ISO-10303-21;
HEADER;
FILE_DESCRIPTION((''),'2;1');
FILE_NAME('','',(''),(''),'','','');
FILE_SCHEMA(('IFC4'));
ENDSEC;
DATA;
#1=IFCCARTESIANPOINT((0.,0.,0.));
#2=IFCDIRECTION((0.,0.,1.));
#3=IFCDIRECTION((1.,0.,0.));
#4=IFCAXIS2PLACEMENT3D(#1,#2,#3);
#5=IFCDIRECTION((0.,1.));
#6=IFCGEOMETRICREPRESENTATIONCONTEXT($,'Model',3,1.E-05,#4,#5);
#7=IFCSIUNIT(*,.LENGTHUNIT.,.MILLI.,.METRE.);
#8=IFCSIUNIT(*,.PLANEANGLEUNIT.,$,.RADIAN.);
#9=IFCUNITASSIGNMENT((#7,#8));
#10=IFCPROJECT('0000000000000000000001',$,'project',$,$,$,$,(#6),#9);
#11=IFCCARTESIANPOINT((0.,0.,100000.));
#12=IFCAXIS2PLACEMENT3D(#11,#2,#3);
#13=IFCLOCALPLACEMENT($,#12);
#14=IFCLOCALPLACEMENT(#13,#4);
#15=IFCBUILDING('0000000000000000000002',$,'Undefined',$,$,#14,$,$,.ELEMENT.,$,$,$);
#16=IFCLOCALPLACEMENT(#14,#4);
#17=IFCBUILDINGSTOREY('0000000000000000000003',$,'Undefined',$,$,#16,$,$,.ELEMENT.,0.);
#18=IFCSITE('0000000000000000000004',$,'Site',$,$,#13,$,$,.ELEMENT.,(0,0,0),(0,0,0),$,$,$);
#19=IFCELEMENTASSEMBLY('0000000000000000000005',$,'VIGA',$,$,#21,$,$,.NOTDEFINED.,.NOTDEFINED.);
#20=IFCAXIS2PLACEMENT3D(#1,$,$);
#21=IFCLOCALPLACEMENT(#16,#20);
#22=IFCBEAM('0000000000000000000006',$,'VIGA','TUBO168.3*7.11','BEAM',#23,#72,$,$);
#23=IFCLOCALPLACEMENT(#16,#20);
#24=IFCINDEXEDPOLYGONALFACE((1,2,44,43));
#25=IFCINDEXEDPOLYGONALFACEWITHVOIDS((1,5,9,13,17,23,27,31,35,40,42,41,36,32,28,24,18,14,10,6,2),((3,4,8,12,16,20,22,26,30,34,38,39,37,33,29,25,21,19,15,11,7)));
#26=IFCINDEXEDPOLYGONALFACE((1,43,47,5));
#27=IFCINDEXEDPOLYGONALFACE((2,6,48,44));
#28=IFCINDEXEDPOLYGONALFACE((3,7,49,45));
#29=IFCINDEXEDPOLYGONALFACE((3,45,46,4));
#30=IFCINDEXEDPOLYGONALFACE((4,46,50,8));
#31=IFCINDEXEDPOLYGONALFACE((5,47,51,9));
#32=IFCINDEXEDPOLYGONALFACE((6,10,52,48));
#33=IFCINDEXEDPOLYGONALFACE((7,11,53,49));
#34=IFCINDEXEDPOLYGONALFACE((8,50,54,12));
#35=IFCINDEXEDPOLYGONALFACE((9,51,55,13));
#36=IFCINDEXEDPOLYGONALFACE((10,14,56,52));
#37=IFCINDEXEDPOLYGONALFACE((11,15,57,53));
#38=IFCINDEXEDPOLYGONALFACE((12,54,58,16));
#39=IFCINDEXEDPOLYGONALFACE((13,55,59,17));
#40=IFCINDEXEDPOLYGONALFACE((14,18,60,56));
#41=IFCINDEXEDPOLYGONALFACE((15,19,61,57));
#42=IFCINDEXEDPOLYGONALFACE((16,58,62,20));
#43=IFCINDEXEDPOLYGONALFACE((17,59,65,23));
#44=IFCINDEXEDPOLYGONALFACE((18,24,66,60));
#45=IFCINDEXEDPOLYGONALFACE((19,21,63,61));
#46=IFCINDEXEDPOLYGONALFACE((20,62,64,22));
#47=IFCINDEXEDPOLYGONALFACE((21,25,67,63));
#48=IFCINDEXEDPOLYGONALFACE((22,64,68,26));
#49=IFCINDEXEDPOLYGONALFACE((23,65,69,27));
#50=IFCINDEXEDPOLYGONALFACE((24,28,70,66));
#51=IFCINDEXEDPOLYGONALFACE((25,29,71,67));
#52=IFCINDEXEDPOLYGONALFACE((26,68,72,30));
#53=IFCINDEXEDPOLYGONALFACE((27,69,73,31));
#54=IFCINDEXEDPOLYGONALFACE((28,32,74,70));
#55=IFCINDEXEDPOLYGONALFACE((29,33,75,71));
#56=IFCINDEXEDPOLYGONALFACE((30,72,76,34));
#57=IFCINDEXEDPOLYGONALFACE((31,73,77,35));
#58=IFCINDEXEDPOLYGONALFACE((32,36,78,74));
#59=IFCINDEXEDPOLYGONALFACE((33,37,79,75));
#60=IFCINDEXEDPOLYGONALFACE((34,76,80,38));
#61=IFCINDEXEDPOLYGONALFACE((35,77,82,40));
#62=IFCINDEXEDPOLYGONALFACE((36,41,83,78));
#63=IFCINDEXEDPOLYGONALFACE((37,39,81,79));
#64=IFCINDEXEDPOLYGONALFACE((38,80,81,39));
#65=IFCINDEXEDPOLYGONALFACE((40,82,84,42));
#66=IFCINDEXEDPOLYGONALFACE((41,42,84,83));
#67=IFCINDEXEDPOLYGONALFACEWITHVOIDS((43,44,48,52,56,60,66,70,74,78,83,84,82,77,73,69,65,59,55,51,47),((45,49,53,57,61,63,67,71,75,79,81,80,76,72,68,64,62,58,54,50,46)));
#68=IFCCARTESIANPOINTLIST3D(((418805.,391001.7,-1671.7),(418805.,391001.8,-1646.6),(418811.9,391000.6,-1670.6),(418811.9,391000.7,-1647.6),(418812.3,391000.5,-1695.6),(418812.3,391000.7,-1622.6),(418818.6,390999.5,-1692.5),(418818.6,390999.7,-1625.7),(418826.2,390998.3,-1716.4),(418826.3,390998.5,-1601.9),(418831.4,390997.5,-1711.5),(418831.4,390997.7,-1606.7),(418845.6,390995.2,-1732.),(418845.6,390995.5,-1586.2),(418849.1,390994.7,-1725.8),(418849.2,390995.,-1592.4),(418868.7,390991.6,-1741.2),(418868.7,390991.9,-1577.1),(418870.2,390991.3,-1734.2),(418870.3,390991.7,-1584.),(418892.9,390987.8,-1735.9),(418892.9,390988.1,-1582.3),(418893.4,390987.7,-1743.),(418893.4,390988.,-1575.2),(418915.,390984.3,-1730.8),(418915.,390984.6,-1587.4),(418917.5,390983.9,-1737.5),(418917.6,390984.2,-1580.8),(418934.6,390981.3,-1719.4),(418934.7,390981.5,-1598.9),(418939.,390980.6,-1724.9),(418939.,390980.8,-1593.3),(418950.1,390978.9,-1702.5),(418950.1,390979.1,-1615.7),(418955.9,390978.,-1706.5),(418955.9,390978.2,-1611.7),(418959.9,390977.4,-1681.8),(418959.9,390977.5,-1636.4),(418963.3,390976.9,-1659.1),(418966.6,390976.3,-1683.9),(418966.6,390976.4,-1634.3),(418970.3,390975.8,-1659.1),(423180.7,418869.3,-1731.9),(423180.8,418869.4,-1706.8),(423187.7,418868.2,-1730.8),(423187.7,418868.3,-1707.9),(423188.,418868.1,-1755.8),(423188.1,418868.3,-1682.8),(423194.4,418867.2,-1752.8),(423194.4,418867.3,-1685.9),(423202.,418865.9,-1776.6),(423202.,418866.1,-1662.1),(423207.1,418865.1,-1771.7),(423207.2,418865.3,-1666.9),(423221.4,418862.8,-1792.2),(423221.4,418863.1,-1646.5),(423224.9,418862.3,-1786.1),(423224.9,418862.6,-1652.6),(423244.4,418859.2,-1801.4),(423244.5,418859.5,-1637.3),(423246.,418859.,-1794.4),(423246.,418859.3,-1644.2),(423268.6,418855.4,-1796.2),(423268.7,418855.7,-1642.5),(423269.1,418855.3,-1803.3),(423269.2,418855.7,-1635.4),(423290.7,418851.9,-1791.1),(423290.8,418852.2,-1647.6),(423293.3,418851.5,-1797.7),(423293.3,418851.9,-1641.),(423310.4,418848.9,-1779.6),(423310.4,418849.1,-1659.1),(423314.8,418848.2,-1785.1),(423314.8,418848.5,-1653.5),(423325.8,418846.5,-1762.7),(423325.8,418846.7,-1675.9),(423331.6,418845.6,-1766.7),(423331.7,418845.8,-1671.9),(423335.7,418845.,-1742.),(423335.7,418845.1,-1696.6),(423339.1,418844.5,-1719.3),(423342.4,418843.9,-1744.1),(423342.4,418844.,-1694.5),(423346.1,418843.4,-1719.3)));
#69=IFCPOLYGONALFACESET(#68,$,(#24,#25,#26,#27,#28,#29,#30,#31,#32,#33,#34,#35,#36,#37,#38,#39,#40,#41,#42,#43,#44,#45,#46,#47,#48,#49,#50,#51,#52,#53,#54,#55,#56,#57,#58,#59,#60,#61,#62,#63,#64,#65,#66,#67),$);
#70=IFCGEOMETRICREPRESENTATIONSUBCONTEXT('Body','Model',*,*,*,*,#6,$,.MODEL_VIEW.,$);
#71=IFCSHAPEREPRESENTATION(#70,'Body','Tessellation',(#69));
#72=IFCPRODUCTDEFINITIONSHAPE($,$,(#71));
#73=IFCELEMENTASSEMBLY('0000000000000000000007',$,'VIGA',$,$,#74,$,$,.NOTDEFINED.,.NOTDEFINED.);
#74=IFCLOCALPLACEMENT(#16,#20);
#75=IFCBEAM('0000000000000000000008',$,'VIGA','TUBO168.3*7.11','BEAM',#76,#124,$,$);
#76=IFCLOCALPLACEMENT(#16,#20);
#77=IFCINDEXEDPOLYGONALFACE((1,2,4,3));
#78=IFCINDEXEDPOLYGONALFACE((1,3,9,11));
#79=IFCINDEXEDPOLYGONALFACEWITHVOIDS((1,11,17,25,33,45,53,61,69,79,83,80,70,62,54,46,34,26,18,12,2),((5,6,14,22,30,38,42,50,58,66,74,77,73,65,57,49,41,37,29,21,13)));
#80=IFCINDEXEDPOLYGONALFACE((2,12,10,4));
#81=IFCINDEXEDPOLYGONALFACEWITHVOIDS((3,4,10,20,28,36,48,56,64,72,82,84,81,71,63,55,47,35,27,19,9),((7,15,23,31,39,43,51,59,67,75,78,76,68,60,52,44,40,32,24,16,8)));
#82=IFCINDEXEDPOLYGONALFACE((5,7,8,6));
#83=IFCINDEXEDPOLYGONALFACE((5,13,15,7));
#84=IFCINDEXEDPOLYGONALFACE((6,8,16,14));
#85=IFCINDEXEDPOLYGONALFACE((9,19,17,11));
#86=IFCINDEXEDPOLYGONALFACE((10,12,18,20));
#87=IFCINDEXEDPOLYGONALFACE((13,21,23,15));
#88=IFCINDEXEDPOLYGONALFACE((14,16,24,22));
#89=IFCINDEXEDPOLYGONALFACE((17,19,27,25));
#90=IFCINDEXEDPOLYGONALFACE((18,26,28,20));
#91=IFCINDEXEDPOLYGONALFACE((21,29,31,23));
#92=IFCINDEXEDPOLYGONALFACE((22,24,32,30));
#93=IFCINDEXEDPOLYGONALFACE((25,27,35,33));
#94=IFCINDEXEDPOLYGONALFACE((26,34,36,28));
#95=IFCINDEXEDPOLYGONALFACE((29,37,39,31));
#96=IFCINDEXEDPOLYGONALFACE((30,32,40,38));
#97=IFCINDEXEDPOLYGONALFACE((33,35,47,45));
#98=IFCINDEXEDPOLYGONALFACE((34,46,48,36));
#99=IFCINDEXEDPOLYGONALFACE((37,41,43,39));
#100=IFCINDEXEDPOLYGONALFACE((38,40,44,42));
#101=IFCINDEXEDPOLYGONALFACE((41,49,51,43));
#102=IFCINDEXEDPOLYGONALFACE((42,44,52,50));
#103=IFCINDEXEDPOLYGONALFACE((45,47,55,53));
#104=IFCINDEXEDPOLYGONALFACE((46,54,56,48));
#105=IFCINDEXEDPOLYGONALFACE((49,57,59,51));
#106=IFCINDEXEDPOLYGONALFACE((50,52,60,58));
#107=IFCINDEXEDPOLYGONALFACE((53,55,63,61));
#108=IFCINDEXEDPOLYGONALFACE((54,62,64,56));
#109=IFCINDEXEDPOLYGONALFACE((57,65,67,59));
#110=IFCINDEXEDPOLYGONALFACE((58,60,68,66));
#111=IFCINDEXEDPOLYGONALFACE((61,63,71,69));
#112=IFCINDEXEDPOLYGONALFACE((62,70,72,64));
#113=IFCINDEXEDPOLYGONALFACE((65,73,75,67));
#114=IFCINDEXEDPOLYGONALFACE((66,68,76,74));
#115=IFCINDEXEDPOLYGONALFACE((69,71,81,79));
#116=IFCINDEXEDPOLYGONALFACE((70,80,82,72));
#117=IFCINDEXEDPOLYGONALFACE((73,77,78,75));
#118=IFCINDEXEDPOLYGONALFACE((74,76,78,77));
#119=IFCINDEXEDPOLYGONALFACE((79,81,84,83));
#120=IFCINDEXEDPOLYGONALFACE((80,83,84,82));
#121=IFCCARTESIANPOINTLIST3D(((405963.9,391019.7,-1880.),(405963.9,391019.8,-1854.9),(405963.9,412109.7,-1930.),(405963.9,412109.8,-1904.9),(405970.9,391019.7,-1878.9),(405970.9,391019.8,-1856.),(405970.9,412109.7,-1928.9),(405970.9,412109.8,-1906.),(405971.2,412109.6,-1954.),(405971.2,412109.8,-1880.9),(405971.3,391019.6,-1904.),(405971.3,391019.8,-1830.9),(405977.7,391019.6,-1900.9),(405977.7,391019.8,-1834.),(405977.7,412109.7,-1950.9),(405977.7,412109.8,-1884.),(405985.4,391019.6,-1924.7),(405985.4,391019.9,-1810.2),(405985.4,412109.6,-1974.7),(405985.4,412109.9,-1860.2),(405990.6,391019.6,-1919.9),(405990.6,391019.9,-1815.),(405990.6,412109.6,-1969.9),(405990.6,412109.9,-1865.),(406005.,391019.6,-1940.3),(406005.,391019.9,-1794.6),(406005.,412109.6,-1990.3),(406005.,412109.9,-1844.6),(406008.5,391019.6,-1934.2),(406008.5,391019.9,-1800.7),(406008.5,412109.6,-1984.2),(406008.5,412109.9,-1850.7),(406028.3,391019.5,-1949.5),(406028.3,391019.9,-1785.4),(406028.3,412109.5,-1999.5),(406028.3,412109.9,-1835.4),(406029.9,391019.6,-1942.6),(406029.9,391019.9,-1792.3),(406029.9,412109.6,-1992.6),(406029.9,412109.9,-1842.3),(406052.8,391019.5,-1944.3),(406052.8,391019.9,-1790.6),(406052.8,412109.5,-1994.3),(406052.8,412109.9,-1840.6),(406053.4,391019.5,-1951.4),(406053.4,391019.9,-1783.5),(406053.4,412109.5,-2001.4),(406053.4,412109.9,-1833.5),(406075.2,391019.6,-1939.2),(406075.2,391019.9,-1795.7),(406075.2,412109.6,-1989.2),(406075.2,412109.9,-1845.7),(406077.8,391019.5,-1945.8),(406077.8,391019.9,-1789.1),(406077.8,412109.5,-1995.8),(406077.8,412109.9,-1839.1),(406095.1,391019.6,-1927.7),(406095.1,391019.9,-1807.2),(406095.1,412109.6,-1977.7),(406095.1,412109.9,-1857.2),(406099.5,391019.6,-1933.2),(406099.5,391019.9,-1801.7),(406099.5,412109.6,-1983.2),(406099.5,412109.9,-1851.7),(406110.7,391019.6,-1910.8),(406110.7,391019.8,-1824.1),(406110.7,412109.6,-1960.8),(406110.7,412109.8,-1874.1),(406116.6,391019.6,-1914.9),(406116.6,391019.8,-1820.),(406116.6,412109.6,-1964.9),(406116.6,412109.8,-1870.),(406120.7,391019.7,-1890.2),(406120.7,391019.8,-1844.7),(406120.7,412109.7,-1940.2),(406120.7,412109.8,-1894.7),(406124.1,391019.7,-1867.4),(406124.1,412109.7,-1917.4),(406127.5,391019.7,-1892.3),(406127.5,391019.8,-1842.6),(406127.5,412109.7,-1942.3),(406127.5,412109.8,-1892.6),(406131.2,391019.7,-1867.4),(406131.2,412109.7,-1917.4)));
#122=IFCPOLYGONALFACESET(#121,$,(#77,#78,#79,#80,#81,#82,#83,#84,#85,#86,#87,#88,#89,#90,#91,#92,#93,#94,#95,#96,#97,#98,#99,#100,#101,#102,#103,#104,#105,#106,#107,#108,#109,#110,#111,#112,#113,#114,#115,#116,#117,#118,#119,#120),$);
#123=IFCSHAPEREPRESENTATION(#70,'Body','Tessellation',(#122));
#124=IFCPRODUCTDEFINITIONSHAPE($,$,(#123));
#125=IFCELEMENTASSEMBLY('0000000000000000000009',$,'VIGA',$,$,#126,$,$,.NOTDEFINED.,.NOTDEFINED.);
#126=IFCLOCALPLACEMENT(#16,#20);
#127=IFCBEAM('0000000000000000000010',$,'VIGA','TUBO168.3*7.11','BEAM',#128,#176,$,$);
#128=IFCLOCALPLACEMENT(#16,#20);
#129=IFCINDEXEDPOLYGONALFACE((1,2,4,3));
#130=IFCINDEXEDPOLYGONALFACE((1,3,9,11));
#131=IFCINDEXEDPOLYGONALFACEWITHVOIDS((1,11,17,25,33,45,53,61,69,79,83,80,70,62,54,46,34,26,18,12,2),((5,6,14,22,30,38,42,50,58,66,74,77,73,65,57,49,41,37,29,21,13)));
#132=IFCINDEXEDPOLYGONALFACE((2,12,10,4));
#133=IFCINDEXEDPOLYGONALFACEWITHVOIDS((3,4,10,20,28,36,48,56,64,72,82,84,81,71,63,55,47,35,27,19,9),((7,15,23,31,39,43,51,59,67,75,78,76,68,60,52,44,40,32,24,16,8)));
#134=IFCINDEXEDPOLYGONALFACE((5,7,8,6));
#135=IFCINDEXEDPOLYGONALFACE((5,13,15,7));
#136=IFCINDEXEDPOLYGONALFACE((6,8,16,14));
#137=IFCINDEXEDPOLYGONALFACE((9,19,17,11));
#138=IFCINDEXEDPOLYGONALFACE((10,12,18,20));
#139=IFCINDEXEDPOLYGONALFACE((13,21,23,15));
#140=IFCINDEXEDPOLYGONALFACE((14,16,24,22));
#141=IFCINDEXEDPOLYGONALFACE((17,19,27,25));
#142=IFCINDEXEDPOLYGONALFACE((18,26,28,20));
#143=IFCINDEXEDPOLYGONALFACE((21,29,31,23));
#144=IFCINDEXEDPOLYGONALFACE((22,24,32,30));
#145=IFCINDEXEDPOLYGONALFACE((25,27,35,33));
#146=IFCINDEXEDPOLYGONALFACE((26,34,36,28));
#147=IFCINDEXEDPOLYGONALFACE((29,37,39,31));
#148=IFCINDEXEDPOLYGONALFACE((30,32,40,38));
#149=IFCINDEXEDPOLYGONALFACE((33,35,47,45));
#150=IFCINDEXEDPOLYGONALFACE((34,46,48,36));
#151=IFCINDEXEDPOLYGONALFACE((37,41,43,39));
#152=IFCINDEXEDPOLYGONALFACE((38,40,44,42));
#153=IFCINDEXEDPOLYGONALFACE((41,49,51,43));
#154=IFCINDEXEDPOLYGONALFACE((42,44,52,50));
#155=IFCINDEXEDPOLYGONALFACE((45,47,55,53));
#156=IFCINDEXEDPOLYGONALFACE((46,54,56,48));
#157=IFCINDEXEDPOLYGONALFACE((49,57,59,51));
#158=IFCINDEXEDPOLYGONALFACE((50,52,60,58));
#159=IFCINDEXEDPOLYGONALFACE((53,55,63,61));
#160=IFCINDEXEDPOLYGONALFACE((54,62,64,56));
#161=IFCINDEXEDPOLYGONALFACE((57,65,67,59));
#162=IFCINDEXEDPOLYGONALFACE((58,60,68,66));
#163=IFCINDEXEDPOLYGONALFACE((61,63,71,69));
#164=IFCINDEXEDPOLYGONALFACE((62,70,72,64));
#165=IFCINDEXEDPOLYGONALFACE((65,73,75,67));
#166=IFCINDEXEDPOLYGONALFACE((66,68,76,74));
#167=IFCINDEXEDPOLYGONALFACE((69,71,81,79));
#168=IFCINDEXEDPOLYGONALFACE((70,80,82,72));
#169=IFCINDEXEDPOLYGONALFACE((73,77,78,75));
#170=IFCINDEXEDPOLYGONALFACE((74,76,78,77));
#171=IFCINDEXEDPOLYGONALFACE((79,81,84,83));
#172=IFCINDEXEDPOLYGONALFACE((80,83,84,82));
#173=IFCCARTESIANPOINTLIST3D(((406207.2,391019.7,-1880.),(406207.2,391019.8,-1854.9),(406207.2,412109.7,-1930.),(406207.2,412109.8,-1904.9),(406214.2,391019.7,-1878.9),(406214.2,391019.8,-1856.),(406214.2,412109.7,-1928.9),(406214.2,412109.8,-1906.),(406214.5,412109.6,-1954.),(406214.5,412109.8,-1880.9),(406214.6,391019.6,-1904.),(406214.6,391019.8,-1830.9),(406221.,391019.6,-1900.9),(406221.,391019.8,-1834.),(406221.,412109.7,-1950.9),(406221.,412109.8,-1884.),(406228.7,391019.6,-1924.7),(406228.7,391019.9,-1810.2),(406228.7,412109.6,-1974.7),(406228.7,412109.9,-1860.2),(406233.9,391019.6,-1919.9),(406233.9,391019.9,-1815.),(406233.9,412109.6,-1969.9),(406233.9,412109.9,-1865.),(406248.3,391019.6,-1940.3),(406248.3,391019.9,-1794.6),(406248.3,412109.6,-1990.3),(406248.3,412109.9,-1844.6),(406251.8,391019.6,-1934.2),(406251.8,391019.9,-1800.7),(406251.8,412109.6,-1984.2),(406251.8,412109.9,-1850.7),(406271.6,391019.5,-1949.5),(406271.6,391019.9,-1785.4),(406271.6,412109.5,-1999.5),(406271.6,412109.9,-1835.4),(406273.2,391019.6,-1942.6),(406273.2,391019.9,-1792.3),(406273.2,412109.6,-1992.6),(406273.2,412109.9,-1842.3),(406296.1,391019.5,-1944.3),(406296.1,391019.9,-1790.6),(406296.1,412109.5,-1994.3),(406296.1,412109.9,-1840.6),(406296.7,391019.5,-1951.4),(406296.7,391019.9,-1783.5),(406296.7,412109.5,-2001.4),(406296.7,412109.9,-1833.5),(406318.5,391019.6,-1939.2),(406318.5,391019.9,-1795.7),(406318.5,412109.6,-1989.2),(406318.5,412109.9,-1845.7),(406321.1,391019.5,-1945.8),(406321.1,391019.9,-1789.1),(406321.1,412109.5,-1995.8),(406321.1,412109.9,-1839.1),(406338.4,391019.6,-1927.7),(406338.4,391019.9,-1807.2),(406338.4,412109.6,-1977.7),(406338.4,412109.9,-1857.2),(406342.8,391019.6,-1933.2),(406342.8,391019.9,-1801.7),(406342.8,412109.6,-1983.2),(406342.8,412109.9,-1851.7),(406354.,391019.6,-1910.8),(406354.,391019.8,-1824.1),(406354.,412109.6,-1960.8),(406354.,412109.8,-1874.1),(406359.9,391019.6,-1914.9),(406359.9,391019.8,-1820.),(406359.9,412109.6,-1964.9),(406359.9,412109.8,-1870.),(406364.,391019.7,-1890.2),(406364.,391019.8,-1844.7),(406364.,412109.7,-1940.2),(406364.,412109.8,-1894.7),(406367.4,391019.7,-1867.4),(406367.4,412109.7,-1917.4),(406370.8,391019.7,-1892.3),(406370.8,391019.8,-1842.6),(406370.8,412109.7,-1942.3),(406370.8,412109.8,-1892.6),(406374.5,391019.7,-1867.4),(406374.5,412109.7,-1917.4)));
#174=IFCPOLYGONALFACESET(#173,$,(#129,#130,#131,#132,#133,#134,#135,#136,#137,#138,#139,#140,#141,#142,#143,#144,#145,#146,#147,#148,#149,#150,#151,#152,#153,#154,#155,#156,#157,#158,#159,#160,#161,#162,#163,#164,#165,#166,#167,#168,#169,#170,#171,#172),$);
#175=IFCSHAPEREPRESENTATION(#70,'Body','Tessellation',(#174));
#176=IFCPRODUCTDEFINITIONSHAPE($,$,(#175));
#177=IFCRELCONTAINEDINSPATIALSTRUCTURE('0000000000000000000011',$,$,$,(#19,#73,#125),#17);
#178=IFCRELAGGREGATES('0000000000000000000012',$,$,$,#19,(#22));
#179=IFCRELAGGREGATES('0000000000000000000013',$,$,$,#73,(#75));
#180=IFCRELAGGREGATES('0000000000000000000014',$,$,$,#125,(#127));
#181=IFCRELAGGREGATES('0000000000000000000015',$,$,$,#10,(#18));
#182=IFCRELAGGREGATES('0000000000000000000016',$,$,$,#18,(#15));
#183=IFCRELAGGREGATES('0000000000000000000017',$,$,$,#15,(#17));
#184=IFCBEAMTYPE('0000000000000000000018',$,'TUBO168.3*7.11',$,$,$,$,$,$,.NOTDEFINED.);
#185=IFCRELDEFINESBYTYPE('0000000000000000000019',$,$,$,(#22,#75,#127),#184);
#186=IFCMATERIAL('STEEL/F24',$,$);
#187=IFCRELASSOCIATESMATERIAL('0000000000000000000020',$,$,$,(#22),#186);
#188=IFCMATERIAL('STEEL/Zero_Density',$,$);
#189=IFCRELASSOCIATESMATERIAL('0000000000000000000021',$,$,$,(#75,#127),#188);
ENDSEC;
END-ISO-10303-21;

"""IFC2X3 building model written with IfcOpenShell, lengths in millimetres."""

from ifc_helpers import new_model, si_unit, direction, frame, origin_with_axes, origin_2d_with_axis, place, context, subcontext, project, spatial, hollow_circle, extrude, material, type_object, element, aggregate, save


model = new_model("IFC2X3")

# Units and contexts
model_context = context("Model", 3, precision=1e-05, world=origin_with_axes(), true_north=direction((0.0, 1.0)))
body_context = subcontext(model_context, "Body", "Model", "MODEL_VIEW")
ifc_project = project(units=[si_unit("LENGTHUNIT", "METRE", prefix="MILLI"), si_unit("PLANEANGLEUNIT", "RADIAN")], contexts=[model_context])

# Site, building, storey
site_placement = place(None, frame((0.0, 0.0, 100000.0), z_axis=(0.0, 0.0, 1.0), x_axis=(1.0, 0.0, 0.0)))
site = spatial("IfcSite", under=ifc_project, at=site_placement, Name="Site", CompositionType="ELEMENT", RefLatitude=(0, 0, 0), RefLongitude=(0, 0, 0))
building_placement = place(site_placement, origin_with_axes())
building = spatial("IfcBuilding", under=site, at=building_placement, Name="Undefined", CompositionType="ELEMENT")
storey_placement = place(building_placement, origin_with_axes())
storey = spatial("IfcBuildingStorey", under=building, at=storey_placement, Name="Undefined", CompositionType="ELEMENT", Elevation=0.0)

# Element assemblies, beams
ifc_material_1 = material(Name="STEEL/F24")
beam_type_1 = type_object("IfcBeamType", Name="TUBO168.3*7.11", PredefinedType="NOTDEFINED")
assembly_1_placement = place(storey_placement, origin_with_axes())
assembly_1 = element("IfcElementAssembly", 1, at=assembly_1_placement, inside=storey, Name="VIGA", AssemblyPlace="NOTDEFINED", PredefinedType="NOTDEFINED")
beam_1_placement = place(assembly_1_placement, frame((418887.2, 390988.8, -1659.1), z_axis=(0.000331, 0.002109, 0.999998), x_axis=(0.155119, 0.987894, -0.002135)))
beam_1 = element("IfcBeam", 2, at=beam_1_placement, type_object=beam_type_1, material=ifc_material_1, Name="VIGA", Description="TUBO168.3*7.11", ObjectType="BEAM", context=body_context, shape_type="SweptSolid", body=[
    extrude(hollow_circle(Radius=84.2, WallThickness=7.1, at=origin_2d_with_axis()), frame((28209.1, 0.0, 0.0), z_axis=(-1.0, 0.0, 0.0), x_axis=(0.0, -1.0, 0.0)), (0.0, 0.0, 1.0), 28209.1),
])
aggregate(assembly_1, [beam_1])
assembly_2_placement = place(storey_placement, origin_with_axes())
assembly_2 = element("IfcElementAssembly", 3, at=assembly_2_placement, inside=storey, Name="VIGA", AssemblyPlace="NOTDEFINED", PredefinedType="NOTDEFINED")
ifc_material_2 = material(Name="STEEL/Zero_Density")
beam_2_placement = place(assembly_2_placement, frame((406047.1, 391019.7, -1867.4), z_axis=(0.0, 0.002371, 0.999997), x_axis=(0.0, 0.999997, -0.002371)))
beam_2 = element("IfcBeam", 4, at=beam_2_placement, type_object=beam_type_1, material=ifc_material_2, Name="VIGA", Description="TUBO168.3*7.11", ObjectType="BEAM", context=body_context, shape_type="SweptSolid", body=[
    extrude(hollow_circle(Radius=84.2, WallThickness=7.1, at=origin_2d_with_axis()), frame((21090.1, 0.0, 0.0), z_axis=(-1.0, 0.0, 0.0), x_axis=(0.0, -1.0, 0.0)), (0.0, 0.0, 1.0), 21090.1),
])
aggregate(assembly_2, [beam_2])
assembly_3_placement = place(storey_placement, origin_with_axes())
assembly_3 = element("IfcElementAssembly", 5, at=assembly_3_placement, inside=storey, Name="VIGA", AssemblyPlace="NOTDEFINED", PredefinedType="NOTDEFINED")
beam_3_placement = place(assembly_3_placement, frame((406290.4, 391019.7, -1867.4), z_axis=(0.0, 0.002371, 0.999997), x_axis=(0.0, 0.999997, -0.002371)))
beam_3 = element("IfcBeam", 6, at=beam_3_placement, type_object=beam_type_1, material=ifc_material_2, Name="VIGA", Description="TUBO168.3*7.11", ObjectType="BEAM", context=body_context, shape_type="SweptSolid", body=[
    extrude(hollow_circle(Radius=84.2, WallThickness=7.1, at=origin_2d_with_axis()), frame((21090.1, 0.0, 0.0), z_axis=(-1.0, 0.0, 0.0), x_axis=(0.0, -1.0, 0.0)), (0.0, 0.0, 1.0), 21090.1),
])
aggregate(assembly_3, [beam_3])

save(model, "model.ifc")
